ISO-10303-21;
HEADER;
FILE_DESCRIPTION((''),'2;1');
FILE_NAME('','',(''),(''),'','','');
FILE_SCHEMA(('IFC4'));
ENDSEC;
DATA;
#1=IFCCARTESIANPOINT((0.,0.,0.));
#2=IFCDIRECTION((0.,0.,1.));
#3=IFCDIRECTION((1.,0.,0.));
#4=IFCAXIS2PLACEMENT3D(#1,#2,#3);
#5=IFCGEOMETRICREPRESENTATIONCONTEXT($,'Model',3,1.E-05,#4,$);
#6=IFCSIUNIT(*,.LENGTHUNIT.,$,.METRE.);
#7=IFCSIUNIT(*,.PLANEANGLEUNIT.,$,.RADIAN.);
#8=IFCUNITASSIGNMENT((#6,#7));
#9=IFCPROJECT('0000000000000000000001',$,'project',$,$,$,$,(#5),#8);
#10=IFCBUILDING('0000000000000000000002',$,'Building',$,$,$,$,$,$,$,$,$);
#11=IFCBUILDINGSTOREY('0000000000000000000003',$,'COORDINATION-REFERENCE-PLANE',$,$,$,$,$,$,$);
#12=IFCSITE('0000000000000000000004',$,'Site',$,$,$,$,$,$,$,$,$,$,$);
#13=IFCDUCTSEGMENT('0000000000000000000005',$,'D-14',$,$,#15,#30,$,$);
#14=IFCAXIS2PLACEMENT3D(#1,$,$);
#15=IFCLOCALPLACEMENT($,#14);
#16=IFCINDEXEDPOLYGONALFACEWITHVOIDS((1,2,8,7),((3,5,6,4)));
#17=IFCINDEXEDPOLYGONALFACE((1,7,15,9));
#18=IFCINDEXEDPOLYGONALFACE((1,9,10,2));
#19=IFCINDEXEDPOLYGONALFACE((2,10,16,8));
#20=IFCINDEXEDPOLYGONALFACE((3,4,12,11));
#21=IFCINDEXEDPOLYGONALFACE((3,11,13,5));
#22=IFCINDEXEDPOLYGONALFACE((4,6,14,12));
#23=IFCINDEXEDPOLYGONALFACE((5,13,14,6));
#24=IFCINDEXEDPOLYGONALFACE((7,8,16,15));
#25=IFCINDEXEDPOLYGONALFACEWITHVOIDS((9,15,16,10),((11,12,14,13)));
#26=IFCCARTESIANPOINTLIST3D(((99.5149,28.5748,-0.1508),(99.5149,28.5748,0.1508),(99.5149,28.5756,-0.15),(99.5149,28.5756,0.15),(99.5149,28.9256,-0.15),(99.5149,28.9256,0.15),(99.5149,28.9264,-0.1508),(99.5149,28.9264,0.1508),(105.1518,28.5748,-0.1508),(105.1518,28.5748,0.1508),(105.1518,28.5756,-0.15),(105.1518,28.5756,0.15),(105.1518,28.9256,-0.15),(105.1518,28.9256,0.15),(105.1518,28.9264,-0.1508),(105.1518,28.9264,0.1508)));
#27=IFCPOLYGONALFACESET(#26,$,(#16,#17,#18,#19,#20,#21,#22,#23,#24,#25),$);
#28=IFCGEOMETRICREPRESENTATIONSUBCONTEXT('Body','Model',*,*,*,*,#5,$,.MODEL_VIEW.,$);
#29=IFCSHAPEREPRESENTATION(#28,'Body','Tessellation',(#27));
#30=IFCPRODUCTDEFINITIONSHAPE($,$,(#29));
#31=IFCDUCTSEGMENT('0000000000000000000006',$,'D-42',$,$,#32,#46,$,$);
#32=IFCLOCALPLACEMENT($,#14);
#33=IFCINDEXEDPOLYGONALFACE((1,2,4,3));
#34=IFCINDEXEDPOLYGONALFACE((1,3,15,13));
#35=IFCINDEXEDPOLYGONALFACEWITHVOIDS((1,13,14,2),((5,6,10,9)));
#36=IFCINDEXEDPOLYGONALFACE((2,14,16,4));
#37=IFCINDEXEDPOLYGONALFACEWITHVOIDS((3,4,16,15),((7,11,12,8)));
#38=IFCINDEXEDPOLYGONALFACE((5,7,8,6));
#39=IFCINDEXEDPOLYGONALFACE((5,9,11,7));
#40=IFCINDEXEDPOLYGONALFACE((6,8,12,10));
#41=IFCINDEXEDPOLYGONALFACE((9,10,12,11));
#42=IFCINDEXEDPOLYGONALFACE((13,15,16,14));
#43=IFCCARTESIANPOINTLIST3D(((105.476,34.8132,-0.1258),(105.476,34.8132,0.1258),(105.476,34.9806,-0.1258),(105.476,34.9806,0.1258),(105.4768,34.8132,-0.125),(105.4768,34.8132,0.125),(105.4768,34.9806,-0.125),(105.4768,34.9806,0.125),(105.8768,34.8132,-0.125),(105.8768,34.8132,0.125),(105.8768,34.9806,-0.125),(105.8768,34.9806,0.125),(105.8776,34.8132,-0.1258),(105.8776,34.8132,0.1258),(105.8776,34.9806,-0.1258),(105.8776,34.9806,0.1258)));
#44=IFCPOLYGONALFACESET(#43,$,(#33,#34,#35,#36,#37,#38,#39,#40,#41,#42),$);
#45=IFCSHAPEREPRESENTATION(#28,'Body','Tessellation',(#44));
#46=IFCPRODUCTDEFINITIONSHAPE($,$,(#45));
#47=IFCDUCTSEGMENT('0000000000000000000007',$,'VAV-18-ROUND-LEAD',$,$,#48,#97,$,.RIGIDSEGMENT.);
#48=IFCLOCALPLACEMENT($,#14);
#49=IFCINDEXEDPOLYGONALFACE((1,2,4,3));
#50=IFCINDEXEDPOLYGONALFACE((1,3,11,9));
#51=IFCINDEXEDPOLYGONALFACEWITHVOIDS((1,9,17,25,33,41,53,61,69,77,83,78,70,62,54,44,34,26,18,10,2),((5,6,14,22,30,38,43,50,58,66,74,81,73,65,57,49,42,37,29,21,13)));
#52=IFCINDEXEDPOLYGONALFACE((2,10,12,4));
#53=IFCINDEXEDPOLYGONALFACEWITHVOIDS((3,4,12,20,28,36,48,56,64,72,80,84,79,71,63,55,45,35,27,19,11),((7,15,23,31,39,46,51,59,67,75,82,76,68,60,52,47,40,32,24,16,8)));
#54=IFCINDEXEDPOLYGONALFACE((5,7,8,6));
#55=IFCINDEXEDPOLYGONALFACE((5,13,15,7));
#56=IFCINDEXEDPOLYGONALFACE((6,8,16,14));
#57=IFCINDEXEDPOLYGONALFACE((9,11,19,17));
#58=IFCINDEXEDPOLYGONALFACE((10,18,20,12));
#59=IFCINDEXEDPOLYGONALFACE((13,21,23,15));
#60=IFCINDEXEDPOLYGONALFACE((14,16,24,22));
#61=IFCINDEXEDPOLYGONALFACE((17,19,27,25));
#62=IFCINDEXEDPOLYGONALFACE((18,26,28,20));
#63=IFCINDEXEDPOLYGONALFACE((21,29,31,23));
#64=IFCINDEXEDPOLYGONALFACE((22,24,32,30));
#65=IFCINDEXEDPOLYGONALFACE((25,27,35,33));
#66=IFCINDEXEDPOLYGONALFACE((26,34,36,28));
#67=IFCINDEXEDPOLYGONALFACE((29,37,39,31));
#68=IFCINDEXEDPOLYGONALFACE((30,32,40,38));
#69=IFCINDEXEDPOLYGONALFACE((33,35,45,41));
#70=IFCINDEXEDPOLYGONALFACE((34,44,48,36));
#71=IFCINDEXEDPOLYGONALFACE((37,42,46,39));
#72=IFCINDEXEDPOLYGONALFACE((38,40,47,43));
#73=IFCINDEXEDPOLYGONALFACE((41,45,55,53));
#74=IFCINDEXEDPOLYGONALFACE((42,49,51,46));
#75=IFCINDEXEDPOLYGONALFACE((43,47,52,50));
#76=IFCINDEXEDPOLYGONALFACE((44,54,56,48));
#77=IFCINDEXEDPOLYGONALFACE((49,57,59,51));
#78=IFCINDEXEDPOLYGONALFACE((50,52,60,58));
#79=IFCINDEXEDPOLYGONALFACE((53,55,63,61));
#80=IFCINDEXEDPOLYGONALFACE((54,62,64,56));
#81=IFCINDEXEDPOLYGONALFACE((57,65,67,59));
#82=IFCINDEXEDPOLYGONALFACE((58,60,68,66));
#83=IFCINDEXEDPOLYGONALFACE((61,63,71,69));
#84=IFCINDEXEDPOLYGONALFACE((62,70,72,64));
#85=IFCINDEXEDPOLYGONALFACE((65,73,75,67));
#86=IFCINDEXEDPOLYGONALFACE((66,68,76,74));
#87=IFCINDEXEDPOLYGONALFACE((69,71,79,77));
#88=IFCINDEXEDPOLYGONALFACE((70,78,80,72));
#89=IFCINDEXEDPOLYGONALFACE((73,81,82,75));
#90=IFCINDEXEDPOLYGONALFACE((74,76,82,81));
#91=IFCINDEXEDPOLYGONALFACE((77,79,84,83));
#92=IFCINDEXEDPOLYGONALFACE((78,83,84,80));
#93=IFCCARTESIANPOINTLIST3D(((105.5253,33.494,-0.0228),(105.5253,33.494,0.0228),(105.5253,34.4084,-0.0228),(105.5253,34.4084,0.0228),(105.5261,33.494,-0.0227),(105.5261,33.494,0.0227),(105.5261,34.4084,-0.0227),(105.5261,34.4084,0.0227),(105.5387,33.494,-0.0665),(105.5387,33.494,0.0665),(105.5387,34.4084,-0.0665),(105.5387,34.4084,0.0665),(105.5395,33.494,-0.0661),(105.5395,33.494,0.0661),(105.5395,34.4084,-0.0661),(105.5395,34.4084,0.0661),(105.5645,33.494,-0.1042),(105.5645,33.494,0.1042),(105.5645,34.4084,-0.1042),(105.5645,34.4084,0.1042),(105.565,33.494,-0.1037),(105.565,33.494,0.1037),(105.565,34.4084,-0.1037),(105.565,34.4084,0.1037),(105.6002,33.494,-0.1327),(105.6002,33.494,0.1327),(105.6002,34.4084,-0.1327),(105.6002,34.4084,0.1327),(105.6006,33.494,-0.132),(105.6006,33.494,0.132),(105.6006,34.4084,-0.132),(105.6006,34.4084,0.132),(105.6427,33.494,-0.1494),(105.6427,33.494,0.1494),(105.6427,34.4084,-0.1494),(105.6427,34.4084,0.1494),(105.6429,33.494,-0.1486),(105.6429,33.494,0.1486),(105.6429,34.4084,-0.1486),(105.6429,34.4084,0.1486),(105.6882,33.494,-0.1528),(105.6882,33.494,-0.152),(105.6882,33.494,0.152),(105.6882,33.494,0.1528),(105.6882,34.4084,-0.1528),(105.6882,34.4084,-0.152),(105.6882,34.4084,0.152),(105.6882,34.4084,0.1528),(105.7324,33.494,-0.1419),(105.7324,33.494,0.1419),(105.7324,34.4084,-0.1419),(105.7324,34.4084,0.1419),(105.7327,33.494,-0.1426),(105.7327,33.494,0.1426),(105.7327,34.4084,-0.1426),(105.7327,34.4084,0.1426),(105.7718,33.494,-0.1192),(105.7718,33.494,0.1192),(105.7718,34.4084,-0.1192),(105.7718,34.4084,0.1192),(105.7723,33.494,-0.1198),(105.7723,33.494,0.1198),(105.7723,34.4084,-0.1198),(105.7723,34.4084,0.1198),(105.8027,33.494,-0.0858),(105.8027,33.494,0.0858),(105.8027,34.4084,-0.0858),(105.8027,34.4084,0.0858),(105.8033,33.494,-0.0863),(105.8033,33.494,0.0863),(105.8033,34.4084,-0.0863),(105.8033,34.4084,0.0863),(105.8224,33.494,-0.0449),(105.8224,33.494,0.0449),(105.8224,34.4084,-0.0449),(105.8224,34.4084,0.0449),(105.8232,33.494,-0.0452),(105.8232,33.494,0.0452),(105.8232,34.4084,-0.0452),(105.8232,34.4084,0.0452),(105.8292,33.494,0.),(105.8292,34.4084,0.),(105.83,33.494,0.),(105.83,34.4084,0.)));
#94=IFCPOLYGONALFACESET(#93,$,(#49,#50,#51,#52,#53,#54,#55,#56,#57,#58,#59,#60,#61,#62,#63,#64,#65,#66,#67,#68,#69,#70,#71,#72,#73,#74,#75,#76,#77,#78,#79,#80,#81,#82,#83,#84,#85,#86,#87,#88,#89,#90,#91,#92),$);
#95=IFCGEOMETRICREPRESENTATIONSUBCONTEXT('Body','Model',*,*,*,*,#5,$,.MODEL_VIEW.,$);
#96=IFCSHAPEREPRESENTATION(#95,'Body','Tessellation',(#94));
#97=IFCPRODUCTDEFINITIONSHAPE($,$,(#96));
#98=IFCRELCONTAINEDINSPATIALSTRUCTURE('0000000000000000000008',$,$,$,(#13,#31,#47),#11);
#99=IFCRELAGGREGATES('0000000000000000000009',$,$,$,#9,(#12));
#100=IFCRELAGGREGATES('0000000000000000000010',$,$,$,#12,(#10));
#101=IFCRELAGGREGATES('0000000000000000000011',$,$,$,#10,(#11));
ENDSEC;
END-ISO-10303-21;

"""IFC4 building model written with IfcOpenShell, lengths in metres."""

from ifc_helpers import new_model, si_unit, frame, origin, origin_with_axes, place, context, subcontext, project, spatial, hollow_rectangle, hollow_circle, extrude, element, save


model = new_model("IFC4")

# Units and contexts
model_context = context("Model", 3, precision=1e-05, world=origin_with_axes())
body_context_1 = subcontext(model_context, "Body", "Model", "MODEL_VIEW")
body_context_2 = subcontext(model_context, "Body", "Model", "MODEL_VIEW")
ifc_project = project(units=[si_unit("LENGTHUNIT", "METRE"), si_unit("PLANEANGLEUNIT", "RADIAN")], contexts=[model_context])

# Site, building, storey
site = spatial("IfcSite", under=ifc_project, Name="Site")
building = spatial("IfcBuilding", under=site, Name="Building")
storey = spatial("IfcBuildingStorey", under=building, Name="COORDINATION-REFERENCE-PLANE")

# Duct segments
duct_segment_1_placement = place(None, frame((99.5149, 28.7506, 0.0), z_axis=(1.0, 0.0, 0.0), x_axis=(0.0, 1.0, 0.0)))
element("IfcDuctSegment", 1, at=duct_segment_1_placement, inside=storey, Name="D-14", context=body_context_1, shape_type="SweptSolid", body=[
    extrude(hollow_rectangle(XDim=0.3516, YDim=0.3016, WallThickness=0.0008), origin(), (0.0, 0.0, 1.0), 5.6369),
])
duct_segment_2_placement = place(None, frame((105.6768, 34.8132, 0.0), z_axis=(0.0, 1.0, 0.0), x_axis=(1.0, 0.0, 0.0)))
element("IfcDuctSegment", 2, at=duct_segment_2_placement, inside=storey, Name="D-42", context=body_context_1, shape_type="SweptSolid", body=[
    extrude(hollow_rectangle(XDim=0.4016, YDim=0.2516, WallThickness=0.0008), origin(), (0.0, 0.0, 1.0), 0.1673),
])

# Duct segment
duct_segment_3_placement = place(None, frame((105.6768, 34.4084, 0.0), z_axis=(0.0, -1.0, 0.0), x_axis=(1.0, 0.0, 0.0)))
element("IfcDuctSegment", 3, at=duct_segment_3_placement, inside=storey, Name="VAV-18-ROUND-LEAD", PredefinedType="RIGIDSEGMENT", context=body_context_2, shape_type="SweptSolid", body=[
    extrude(hollow_circle(Radius=0.1532, WallThickness=0.0008), origin(), (0.0, 0.0, 1.0), 0.9144),
])

save(model, "model.ifc")
